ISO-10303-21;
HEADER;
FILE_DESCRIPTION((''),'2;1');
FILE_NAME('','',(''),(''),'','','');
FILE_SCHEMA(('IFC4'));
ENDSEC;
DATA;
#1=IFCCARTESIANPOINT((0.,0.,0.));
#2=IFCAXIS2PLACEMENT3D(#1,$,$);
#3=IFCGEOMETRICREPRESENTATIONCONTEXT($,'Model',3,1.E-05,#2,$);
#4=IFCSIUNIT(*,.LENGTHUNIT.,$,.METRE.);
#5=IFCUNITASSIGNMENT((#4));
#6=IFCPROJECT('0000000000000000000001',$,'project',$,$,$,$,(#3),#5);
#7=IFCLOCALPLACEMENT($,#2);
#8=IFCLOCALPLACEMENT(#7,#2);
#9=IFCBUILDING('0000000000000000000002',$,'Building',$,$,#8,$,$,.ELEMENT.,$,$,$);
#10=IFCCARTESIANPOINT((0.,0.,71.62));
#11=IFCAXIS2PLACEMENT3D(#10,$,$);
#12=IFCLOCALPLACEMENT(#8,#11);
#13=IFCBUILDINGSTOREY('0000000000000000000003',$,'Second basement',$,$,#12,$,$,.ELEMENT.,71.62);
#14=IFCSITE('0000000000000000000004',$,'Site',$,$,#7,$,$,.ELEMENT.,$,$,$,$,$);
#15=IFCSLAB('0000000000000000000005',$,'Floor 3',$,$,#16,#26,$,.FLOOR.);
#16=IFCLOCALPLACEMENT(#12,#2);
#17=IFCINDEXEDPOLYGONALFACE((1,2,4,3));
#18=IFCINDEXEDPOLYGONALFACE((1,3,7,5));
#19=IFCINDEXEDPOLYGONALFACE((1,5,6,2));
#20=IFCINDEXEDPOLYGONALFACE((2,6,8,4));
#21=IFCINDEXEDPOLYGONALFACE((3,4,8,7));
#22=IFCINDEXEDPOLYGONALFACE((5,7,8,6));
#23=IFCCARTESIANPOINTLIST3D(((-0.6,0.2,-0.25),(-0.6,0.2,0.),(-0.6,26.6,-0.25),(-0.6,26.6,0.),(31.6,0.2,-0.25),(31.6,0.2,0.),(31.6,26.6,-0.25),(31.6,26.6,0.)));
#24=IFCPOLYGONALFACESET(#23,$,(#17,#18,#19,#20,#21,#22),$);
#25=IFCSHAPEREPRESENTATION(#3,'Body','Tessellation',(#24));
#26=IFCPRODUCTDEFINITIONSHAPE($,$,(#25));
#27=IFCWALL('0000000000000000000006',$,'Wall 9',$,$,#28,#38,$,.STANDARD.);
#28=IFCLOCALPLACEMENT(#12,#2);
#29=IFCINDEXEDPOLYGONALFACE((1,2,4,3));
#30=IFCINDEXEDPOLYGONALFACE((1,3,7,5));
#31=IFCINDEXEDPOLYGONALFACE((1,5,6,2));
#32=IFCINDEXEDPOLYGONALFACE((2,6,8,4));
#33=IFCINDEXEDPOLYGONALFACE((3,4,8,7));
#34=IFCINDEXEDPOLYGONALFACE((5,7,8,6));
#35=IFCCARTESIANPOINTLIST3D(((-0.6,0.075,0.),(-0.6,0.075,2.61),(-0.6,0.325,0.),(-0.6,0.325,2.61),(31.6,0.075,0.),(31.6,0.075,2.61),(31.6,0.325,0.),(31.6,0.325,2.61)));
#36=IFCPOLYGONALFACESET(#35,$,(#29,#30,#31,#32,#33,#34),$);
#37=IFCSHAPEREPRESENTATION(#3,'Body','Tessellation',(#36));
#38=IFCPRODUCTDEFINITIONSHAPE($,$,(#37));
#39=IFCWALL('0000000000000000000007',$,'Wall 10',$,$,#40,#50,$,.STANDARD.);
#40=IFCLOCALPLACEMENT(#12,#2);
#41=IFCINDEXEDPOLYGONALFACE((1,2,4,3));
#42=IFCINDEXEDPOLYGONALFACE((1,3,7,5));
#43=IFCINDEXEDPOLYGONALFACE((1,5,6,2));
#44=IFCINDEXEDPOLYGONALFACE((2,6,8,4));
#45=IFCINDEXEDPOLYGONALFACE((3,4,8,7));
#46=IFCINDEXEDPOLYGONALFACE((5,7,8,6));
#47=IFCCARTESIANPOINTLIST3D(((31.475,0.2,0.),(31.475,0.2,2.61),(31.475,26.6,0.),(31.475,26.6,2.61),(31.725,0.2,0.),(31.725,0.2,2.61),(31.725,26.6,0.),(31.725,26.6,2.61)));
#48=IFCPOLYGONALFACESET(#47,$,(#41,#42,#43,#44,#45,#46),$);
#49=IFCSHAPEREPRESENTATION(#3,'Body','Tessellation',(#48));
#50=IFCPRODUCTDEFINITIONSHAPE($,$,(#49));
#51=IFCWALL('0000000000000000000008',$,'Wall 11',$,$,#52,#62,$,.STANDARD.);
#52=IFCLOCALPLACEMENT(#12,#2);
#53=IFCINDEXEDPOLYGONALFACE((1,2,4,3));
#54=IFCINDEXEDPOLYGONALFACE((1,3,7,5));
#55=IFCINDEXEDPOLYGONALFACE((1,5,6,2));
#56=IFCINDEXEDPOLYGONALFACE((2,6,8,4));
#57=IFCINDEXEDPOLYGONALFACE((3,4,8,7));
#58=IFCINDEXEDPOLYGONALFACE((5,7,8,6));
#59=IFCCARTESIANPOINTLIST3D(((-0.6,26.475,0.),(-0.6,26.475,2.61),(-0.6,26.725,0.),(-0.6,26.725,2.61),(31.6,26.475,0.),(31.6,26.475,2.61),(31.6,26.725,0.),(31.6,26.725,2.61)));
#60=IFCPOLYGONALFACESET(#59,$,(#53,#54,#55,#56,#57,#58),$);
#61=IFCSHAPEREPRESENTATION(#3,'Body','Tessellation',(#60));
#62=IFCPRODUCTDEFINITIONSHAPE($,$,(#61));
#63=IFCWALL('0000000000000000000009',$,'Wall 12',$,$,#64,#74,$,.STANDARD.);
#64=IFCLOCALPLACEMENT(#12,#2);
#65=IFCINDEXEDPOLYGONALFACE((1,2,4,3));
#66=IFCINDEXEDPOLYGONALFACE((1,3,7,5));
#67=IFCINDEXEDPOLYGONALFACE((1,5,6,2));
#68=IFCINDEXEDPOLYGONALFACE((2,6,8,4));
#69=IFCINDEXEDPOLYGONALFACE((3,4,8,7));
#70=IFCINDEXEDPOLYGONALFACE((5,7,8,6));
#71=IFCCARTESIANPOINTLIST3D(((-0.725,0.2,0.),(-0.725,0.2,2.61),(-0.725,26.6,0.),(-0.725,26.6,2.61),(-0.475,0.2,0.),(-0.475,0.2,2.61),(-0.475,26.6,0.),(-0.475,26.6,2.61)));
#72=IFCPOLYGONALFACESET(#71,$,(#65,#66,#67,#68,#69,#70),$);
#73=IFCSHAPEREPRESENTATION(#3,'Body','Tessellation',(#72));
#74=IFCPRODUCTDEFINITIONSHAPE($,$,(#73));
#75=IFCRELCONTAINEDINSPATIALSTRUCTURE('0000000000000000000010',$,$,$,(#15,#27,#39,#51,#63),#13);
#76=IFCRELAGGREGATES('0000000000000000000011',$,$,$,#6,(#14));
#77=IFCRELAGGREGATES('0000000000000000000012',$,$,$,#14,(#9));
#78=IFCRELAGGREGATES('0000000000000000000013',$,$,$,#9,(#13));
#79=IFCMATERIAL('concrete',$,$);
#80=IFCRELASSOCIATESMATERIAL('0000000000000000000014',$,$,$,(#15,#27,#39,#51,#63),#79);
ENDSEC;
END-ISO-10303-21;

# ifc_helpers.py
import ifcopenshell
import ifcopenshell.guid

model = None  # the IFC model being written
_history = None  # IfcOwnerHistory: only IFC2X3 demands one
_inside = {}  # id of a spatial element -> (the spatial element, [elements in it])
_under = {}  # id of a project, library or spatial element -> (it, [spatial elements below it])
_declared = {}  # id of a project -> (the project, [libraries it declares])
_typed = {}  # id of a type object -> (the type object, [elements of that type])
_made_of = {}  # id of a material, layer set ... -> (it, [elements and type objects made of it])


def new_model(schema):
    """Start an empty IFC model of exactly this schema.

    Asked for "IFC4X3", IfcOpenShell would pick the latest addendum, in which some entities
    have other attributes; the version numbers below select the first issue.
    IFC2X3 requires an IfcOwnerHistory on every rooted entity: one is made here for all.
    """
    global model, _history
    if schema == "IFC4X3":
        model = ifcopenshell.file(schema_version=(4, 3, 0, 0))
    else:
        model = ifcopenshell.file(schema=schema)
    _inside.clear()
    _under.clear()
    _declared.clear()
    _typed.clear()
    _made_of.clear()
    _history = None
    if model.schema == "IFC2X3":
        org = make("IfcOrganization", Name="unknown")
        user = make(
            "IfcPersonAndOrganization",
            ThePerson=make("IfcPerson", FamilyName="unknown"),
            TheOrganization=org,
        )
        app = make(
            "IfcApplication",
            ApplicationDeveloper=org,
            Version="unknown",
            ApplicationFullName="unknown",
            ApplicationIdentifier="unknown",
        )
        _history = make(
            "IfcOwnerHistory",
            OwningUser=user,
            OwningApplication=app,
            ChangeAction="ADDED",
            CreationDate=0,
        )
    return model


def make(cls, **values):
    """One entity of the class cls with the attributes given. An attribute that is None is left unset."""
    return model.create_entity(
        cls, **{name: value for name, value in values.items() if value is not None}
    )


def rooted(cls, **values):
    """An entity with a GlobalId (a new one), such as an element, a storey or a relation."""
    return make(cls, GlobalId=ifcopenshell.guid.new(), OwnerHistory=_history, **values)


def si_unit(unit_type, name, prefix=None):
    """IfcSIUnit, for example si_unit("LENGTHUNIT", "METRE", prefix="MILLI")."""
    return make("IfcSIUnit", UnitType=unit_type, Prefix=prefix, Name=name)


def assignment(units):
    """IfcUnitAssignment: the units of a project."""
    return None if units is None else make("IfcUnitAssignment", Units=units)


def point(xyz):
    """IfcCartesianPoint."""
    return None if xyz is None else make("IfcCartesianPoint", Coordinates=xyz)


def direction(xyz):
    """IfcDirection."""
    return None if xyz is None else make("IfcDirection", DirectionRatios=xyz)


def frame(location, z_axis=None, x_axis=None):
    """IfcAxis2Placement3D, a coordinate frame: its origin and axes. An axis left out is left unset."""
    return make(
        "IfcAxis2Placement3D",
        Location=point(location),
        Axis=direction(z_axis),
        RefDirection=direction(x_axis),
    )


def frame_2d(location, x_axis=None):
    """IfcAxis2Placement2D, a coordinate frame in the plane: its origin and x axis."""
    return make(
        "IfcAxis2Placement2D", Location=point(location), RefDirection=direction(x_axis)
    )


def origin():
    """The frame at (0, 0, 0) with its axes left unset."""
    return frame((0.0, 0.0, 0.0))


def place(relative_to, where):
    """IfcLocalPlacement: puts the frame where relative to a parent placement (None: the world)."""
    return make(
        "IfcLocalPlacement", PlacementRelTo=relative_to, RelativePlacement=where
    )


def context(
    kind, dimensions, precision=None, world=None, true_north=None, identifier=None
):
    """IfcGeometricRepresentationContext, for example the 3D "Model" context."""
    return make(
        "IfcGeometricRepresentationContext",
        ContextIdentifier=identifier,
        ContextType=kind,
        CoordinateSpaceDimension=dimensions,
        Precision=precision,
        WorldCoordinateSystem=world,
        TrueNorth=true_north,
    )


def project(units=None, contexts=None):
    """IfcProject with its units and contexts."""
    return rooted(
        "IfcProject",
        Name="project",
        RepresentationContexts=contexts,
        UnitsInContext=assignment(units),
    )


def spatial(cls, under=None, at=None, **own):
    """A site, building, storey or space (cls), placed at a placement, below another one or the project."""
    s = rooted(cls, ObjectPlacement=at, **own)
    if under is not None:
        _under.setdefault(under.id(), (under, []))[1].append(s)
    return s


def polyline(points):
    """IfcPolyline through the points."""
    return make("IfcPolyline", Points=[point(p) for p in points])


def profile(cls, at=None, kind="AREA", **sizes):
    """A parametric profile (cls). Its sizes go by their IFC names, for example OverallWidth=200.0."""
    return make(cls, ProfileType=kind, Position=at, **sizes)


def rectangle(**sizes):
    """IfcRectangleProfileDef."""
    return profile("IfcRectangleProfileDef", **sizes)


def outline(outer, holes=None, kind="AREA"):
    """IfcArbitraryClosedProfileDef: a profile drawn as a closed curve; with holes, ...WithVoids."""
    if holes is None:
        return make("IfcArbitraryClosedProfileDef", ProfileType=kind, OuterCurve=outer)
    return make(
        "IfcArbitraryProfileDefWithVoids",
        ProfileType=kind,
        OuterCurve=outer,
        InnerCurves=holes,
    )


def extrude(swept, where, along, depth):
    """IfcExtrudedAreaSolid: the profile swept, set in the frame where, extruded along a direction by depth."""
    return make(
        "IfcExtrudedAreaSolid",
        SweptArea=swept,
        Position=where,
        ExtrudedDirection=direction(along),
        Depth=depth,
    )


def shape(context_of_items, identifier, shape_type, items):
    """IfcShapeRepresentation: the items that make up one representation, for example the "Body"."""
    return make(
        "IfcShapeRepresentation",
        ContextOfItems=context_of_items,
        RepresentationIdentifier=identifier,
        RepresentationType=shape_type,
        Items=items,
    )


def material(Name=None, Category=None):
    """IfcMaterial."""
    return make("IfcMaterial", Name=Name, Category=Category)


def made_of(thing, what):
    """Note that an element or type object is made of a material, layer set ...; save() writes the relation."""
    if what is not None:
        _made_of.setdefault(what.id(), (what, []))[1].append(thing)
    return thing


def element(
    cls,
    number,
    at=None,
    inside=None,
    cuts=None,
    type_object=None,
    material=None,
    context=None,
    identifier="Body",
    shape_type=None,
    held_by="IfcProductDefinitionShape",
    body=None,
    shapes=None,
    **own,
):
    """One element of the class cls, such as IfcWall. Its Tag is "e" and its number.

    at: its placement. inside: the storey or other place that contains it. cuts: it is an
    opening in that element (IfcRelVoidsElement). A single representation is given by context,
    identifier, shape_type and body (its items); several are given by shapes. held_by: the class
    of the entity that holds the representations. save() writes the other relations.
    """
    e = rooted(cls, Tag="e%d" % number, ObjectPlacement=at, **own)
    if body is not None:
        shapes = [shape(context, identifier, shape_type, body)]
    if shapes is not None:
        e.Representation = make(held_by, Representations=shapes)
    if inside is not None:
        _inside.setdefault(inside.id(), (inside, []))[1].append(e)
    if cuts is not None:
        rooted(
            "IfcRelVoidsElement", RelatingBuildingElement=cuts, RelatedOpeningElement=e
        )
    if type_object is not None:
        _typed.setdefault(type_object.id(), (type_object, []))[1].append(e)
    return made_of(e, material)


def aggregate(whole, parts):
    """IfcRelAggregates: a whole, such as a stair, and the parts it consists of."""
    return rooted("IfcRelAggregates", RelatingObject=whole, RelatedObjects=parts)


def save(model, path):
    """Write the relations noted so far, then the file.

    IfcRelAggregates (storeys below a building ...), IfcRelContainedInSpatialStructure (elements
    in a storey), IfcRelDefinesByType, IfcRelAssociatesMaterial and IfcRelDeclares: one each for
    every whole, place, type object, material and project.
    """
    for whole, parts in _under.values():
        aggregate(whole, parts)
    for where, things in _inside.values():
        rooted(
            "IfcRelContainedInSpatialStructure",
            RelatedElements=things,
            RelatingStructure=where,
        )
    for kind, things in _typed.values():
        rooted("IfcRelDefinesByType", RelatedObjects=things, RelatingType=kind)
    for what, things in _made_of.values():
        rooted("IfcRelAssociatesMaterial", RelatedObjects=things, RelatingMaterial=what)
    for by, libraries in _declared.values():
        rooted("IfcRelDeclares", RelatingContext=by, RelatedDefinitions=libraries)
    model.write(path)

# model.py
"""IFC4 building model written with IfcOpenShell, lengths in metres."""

from ifc_helpers import new_model, si_unit, frame, frame_2d, origin, place, context, project, spatial, polyline, rectangle, outline, extrude, material, element, save


model = new_model("IFC4")

# Units and contexts
model_context = context("Model", 3, precision=1e-05, world=origin())
ifc_project = project(units=[si_unit("LENGTHUNIT", "METRE")], contexts=[model_context])

# Site, building, storey
site_placement = place(None, origin())
site = spatial("IfcSite", under=ifc_project, at=site_placement, Name="Site", CompositionType="ELEMENT")
building_placement = place(site_placement, origin())
building = spatial("IfcBuilding", under=site, at=building_placement, Name="Building", CompositionType="ELEMENT")
storey_placement = place(building_placement, frame((0.0, 0.0, 71.62)))
storey = spatial("IfcBuildingStorey", under=building, at=storey_placement, Name="Second basement", CompositionType="ELEMENT", Elevation=71.62)

# Slab
ifc_material = material(Name="concrete")
slab_placement = place(storey_placement, frame((0.0, 0.0, -0.25), z_axis=(0.0, 0.0, 1.0), x_axis=(1.0, 0.0, 0.0)))
element("IfcSlab", 1, at=slab_placement, inside=storey, material=ifc_material, Name="Floor 3", PredefinedType="FLOOR", context=model_context, shape_type="SweptSolid", body=[
    extrude(outline(polyline([(-0.6, 0.2), (31.6, 0.2), (31.6, 26.6), (-0.6, 26.6), (-0.6, 0.2)])), origin(), (0.0, 0.0, 1.0), 0.25),
])

# Walls
wall_1_placement = place(storey_placement, frame((-0.6, 0.2, 0.0), z_axis=(0.0, 0.0, 1.0), x_axis=(1.0, 0.0, 0.0)))
element("IfcWall", 2, at=wall_1_placement, inside=storey, material=ifc_material, Name="Wall 9", PredefinedType="STANDARD", context=model_context, shape_type="SweptSolid", body=[
    extrude(rectangle(XDim=32.2, YDim=0.25, at=frame_2d((16.1, 0.0))), origin(), (0.0, 0.0, 1.0), 2.61),
])
wall_2_placement = place(storey_placement, frame((31.6, 0.2, 0.0), z_axis=(0.0, 0.0, 1.0), x_axis=(0.0, 1.0, 0.0)))
element("IfcWall", 3, at=wall_2_placement, inside=storey, material=ifc_material, Name="Wall 10", PredefinedType="STANDARD", context=model_context, shape_type="SweptSolid", body=[
    extrude(rectangle(XDim=26.4, YDim=0.25, at=frame_2d((13.2, 0.0))), origin(), (0.0, 0.0, 1.0), 2.61),
])
wall_3_placement = place(storey_placement, frame((31.6, 26.6, 0.0), z_axis=(0.0, 0.0, 1.0), x_axis=(-1.0, 0.0, 0.0)))
element("IfcWall", 4, at=wall_3_placement, inside=storey, material=ifc_material, Name="Wall 11", PredefinedType="STANDARD", context=model_context, shape_type="SweptSolid", body=[
    extrude(rectangle(XDim=32.2, YDim=0.25, at=frame_2d((16.1, 0.0))), origin(), (0.0, 0.0, 1.0), 2.61),
])
wall_4_placement = place(storey_placement, frame((-0.6, 26.6, 0.0), z_axis=(0.0, 0.0, 1.0), x_axis=(0.0, -1.0, 0.0)))
element("IfcWall", 5, at=wall_4_placement, inside=storey, material=ifc_material, Name="Wall 12", PredefinedType="STANDARD", context=model_context, shape_type="SweptSolid", body=[
    extrude(rectangle(XDim=26.4, YDim=0.25, at=frame_2d((13.2, 0.0))), origin(), (0.0, 0.0, 1.0), 2.61),
])

save(model, "model.ifc")
